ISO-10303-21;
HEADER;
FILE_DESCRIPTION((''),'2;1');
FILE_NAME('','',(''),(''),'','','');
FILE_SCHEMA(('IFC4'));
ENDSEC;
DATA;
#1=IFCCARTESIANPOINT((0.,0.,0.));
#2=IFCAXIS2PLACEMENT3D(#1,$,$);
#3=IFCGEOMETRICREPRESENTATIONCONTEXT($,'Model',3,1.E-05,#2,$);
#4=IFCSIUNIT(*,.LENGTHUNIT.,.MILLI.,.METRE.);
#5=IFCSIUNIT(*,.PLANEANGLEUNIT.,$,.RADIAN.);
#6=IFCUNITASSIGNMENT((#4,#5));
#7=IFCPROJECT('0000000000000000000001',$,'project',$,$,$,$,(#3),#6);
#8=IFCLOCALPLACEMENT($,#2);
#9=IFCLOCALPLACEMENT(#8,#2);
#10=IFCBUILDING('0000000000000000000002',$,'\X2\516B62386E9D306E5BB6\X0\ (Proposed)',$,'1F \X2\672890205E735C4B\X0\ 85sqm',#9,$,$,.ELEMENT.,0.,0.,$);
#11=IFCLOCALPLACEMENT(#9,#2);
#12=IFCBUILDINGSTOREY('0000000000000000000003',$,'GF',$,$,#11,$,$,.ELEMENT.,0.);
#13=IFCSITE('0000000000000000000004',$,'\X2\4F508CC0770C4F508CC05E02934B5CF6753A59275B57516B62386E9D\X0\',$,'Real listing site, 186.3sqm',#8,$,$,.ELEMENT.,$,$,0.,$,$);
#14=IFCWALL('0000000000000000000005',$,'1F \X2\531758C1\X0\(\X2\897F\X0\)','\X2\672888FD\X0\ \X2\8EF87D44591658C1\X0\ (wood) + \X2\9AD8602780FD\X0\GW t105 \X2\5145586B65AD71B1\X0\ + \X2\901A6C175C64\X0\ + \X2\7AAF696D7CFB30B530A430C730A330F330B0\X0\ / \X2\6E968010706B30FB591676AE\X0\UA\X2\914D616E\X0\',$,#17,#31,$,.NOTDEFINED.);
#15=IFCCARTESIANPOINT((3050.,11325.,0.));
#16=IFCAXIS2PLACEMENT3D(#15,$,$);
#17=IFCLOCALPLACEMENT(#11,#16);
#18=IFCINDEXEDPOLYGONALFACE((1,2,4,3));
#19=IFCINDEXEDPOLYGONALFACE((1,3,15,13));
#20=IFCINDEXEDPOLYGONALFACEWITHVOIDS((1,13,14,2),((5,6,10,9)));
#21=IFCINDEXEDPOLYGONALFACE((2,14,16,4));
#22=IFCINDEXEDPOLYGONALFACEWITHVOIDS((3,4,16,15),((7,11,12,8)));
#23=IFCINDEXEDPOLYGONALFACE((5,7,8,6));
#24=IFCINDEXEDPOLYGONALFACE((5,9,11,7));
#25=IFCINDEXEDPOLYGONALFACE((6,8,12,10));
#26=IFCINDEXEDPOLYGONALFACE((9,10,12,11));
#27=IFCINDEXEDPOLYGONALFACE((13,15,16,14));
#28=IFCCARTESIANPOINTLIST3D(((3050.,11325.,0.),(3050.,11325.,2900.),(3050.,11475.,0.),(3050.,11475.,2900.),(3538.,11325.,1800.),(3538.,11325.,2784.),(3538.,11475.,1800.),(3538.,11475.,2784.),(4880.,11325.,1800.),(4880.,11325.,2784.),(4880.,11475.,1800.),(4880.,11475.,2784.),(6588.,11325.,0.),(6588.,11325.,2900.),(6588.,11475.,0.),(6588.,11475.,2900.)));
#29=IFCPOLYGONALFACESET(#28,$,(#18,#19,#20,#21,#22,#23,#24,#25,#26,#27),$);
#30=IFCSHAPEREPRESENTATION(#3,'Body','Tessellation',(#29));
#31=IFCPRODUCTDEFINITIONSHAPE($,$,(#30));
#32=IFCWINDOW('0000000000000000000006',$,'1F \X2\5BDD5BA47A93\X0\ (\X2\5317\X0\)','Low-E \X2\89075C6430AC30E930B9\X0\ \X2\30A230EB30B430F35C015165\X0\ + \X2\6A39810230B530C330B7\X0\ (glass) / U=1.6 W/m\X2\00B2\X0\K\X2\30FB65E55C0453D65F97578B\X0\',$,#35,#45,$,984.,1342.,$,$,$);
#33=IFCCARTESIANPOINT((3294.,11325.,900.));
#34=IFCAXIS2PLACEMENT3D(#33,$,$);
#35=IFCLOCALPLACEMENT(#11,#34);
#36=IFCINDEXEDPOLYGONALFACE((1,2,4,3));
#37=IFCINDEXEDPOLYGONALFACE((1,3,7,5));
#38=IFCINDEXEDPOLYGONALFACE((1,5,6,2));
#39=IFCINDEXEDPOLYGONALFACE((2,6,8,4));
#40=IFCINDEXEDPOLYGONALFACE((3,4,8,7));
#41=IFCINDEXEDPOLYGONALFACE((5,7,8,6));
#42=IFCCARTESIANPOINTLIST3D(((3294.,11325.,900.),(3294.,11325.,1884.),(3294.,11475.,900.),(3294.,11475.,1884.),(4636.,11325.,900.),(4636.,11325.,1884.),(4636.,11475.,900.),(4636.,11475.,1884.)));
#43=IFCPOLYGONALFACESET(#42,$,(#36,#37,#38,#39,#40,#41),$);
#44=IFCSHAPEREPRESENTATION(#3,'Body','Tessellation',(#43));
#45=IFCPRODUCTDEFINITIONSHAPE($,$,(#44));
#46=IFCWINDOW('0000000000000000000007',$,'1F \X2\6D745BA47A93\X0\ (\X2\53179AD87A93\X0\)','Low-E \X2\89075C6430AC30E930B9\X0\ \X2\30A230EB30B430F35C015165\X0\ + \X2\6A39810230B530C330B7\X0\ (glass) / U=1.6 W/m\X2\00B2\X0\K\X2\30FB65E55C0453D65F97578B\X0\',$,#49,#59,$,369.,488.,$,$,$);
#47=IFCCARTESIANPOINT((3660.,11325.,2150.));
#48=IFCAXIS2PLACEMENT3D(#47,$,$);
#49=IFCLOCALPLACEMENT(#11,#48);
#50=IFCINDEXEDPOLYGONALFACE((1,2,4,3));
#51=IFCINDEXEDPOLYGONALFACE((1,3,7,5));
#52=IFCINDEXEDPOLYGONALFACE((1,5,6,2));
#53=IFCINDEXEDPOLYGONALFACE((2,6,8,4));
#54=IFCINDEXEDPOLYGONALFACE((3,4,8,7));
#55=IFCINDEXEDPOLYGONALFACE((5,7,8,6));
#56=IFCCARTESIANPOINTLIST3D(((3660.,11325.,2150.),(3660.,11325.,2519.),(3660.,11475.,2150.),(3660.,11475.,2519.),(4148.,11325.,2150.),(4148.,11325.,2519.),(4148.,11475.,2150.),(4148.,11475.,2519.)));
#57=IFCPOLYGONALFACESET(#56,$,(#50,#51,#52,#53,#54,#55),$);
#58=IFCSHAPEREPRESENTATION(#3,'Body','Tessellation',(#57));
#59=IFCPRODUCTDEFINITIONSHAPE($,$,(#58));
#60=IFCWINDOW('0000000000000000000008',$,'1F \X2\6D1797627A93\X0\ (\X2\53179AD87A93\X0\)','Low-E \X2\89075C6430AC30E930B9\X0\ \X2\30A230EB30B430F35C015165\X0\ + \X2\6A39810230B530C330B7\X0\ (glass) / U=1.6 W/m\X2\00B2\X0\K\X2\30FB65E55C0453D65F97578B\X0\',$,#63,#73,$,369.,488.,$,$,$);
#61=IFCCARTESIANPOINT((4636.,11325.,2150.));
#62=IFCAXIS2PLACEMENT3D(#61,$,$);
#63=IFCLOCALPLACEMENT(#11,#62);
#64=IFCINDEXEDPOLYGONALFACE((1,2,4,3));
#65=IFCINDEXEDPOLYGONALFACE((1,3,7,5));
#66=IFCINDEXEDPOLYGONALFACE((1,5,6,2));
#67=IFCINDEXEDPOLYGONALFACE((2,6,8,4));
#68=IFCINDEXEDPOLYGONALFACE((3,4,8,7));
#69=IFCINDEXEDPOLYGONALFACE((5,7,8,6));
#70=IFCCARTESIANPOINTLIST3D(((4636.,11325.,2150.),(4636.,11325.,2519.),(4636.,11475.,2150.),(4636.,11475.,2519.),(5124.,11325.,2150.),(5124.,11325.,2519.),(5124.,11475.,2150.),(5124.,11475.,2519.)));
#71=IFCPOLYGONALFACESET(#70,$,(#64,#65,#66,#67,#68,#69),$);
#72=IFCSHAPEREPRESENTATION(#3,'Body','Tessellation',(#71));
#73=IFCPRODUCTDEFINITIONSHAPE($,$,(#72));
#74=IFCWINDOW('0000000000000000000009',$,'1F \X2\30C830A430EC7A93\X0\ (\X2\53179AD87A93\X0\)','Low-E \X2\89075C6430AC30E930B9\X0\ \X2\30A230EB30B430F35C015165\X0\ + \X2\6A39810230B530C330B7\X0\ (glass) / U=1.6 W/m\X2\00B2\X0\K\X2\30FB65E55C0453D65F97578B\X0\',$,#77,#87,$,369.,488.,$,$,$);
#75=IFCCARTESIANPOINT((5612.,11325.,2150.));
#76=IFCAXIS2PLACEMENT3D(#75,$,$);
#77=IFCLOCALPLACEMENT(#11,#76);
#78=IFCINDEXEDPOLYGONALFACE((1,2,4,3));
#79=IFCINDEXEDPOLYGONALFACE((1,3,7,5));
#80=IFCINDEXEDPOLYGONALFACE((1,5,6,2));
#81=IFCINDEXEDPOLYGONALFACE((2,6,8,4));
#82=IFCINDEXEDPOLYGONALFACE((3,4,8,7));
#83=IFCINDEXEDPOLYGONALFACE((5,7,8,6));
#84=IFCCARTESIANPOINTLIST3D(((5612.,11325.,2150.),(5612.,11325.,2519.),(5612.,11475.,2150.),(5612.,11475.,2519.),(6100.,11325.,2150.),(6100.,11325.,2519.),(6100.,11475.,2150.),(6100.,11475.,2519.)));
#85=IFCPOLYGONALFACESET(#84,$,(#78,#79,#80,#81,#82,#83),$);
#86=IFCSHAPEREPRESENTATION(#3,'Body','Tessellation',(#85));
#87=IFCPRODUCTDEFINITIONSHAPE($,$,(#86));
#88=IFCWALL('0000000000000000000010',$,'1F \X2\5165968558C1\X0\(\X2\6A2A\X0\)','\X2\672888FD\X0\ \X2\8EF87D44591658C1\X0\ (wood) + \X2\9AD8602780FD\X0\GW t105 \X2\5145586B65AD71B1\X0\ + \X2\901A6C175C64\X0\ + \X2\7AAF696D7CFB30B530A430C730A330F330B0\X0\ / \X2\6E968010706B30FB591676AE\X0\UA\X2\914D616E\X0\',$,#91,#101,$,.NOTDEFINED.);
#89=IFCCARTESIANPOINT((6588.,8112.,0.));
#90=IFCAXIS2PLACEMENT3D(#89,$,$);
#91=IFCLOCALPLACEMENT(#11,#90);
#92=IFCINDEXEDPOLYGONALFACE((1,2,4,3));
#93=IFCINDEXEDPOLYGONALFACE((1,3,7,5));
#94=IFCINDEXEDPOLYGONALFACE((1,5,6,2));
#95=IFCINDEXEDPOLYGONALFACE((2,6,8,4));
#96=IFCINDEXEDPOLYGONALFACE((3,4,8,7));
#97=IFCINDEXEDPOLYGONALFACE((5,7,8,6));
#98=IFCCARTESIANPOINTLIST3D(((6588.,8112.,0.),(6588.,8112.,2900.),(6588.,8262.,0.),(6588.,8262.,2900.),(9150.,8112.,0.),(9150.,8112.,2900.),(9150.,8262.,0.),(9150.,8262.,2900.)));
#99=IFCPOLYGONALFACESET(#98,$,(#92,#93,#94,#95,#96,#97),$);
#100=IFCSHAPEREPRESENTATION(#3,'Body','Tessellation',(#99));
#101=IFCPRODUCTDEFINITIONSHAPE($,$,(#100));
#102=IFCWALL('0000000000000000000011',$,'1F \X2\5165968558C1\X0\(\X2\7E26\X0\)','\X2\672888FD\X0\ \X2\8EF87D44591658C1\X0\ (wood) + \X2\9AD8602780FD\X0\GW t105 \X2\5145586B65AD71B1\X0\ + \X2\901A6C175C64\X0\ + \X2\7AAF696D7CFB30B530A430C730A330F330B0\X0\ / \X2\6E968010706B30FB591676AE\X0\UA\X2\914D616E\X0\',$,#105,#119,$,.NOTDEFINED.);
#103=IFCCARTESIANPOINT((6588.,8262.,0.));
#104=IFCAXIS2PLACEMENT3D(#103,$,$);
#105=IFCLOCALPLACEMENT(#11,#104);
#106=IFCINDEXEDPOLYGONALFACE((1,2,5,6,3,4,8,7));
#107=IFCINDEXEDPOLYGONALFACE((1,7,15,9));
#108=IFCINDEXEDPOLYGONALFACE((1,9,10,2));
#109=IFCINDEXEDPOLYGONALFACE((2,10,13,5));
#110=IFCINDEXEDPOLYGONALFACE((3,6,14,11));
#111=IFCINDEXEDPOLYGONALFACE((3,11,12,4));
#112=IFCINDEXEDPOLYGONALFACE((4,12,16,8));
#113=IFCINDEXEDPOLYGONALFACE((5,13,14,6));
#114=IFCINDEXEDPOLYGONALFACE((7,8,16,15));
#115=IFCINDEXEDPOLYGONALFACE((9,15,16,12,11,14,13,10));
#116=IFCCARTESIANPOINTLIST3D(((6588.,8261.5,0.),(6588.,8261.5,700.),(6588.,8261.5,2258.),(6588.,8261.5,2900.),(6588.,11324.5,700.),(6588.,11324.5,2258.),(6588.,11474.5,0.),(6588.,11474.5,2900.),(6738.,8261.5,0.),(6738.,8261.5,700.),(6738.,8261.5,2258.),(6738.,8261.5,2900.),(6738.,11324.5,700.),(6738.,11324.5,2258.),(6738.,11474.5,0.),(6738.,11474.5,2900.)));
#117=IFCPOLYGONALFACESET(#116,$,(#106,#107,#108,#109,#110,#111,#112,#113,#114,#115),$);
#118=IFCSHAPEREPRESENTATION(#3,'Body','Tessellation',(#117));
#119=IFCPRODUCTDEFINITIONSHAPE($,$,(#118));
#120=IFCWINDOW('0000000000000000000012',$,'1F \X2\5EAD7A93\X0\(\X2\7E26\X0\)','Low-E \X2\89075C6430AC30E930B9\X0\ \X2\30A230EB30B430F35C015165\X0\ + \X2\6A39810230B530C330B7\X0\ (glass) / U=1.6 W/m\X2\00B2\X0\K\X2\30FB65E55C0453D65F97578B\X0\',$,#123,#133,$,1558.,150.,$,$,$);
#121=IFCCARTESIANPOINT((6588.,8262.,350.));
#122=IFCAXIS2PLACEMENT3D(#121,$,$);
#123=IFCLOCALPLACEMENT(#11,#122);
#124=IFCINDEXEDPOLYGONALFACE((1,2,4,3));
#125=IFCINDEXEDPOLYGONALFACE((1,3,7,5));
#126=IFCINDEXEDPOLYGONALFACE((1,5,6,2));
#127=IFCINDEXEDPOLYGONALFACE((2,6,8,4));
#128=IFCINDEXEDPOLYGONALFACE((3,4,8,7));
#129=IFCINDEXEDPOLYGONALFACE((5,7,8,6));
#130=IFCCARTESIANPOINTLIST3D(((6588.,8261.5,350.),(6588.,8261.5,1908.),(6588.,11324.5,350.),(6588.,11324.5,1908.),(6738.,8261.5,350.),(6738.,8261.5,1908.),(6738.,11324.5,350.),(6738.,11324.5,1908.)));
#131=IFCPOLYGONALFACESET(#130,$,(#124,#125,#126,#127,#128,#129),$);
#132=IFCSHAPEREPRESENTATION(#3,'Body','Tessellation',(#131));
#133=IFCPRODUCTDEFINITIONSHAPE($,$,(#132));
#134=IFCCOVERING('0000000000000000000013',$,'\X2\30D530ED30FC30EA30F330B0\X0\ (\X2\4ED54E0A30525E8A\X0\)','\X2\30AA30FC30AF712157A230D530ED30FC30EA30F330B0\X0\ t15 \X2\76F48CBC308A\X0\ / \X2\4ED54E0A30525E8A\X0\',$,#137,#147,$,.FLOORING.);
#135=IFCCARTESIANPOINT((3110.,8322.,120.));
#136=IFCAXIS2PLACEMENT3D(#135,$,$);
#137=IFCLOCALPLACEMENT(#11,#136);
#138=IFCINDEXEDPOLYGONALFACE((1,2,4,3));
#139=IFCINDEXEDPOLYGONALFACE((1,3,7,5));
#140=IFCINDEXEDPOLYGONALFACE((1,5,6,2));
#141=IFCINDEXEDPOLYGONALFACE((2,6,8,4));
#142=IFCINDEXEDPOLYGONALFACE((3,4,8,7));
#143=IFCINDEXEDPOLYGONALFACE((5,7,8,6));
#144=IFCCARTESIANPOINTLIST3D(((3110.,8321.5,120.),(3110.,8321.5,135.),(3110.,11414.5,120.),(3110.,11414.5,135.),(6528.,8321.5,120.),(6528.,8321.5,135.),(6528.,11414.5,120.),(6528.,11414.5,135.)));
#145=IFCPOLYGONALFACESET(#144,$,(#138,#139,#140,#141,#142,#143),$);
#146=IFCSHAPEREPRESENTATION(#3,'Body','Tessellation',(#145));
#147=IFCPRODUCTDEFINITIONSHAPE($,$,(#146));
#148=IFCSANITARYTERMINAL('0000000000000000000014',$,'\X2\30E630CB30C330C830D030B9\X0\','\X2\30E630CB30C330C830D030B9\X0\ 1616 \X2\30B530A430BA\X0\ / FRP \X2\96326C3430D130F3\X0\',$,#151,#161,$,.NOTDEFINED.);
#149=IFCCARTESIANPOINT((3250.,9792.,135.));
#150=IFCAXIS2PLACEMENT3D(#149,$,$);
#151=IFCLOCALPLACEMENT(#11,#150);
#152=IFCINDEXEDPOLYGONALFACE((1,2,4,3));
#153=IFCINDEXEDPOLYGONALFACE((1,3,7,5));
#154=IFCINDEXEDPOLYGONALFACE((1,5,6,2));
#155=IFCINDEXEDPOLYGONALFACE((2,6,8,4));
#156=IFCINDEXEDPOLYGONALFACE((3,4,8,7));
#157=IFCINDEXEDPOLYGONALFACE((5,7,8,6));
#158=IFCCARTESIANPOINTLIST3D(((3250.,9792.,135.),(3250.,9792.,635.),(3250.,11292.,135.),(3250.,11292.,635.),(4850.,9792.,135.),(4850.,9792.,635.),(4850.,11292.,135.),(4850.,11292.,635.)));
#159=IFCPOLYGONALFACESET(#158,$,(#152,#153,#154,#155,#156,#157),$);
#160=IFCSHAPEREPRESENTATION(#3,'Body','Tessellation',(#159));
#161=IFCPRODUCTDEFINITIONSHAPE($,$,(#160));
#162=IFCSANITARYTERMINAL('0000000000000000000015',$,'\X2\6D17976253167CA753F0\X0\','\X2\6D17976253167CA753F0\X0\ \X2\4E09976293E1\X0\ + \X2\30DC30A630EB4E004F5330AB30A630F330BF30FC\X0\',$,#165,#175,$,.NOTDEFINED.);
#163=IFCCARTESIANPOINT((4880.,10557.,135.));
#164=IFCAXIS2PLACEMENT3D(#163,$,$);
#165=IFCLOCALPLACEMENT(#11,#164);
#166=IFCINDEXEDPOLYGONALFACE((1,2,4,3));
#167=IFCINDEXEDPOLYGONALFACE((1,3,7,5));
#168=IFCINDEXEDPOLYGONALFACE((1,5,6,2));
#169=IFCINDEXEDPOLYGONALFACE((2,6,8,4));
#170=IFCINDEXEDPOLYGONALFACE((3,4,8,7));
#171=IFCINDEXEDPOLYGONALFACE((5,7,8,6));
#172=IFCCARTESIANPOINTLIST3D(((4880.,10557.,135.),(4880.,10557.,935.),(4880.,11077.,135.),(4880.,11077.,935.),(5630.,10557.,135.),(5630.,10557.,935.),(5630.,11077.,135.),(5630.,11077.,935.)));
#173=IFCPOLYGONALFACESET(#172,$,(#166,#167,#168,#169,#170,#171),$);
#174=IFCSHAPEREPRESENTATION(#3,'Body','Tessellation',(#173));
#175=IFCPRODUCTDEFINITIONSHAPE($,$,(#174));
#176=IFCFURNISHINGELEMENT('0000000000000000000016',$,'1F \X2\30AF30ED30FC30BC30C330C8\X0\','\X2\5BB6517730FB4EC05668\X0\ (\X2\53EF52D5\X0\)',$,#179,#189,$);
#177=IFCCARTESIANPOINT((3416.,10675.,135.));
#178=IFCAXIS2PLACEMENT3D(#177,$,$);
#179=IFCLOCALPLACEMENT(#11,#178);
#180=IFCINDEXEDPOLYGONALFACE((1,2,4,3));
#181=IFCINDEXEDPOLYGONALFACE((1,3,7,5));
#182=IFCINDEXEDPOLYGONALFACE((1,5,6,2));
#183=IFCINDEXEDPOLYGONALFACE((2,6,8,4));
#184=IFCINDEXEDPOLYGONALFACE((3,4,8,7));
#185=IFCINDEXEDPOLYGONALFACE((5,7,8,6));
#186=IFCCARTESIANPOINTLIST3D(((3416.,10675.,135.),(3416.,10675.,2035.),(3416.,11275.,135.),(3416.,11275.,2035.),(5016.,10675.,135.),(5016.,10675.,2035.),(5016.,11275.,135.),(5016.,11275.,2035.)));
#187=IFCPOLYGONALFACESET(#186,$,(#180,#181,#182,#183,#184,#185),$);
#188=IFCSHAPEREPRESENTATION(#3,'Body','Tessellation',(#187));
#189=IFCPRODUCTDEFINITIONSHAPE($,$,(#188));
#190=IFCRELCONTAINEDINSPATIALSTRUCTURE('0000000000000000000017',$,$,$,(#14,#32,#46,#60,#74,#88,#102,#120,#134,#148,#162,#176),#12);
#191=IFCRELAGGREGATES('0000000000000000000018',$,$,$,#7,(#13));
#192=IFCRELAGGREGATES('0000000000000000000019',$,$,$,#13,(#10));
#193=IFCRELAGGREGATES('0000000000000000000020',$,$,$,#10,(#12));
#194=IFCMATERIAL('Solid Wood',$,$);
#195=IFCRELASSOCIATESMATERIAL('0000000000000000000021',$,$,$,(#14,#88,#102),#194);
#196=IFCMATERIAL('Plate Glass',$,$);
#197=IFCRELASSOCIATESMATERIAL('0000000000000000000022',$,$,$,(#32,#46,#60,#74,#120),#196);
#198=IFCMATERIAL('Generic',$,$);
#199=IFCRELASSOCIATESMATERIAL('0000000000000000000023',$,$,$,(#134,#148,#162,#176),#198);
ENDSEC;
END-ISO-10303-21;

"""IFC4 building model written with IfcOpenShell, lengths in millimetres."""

from ifc_helpers import new_model, si_unit, frame, frame_2d, origin, place, context, project, spatial, rectangle, extrude, material, element, fill, save


model = new_model("IFC4")

# Units and contexts
model_context = context("Model", 3, precision=1e-05, world=origin())
ifc_project = project(units=[si_unit("LENGTHUNIT", "METRE", prefix="MILLI"), si_unit("PLANEANGLEUNIT", "RADIAN")], contexts=[model_context])

# Site, building, storey
site_placement = place(None, origin())
site = spatial("IfcSite", under=ifc_project, at=site_placement, Name="佐賀県佐賀市鍋島町大字八戸溝", ObjectType="Real listing site, 186.3sqm", CompositionType="ELEMENT", RefElevation=0.0)
building_placement = place(site_placement, origin())
building = spatial("IfcBuilding", under=site, at=building_placement, Name="八戸溝の家 (Proposed)", ObjectType="1F 木造平屋 85sqm", CompositionType="ELEMENT", ElevationOfRefHeight=0.0, ElevationOfTerrain=0.0)
storey_placement = place(building_placement, origin())
storey = spatial("IfcBuildingStorey", under=building, at=storey_placement, Name="GF", CompositionType="ELEMENT", Elevation=0.0)

# Shared definitions
ifc_material_1 = material(Name="Solid Wood")

# Wall, openings, windows
wall_1_placement = place(storey_placement, frame((3050.0, 11325.0, 0.0)))
wall_1 = element("IfcWall", 1, at=wall_1_placement, inside=storey, material=ifc_material_1, Name="1F 北壁(西)", Description="木製 軸組外壁 (wood) + 高性能GW t105 充填断熱 + 通気層 + 窯業系サイディング / 準耐火・外皮UA配慮", PredefinedType="NOTDEFINED", context=model_context, shape_type="SweptSolid", body=[
    extrude(rectangle(XDim=3538.0, YDim=150.0, at=frame_2d((1769.0, 75.0))), frame((3050.0, 11325.0, 0.0)), (0.0, 0.0, 1.0), 2900.0),
])
opening_1_placement = place(storey_placement, frame((3294.0, 11325.0, 900.0)))
opening_1 = element("IfcOpeningElement", 2, at=opening_1_placement, cuts=wall_1, PredefinedType="NOTDEFINED", context=model_context, shape_type="SweptSolid", body=[
    extrude(rectangle(XDim=1342.0, YDim=150.0, at=frame_2d((671.0, 75.0))), frame((3294.0, 11325.0, 900.0)), (0.0, 0.0, 1.0), 984.0),
])
opening_2_placement = place(storey_placement, frame((3660.0, 11325.0, 2150.0)))
opening_2 = element("IfcOpeningElement", 3, at=opening_2_placement, cuts=wall_1, PredefinedType="NOTDEFINED", context=model_context, shape_type="SweptSolid", body=[
    extrude(rectangle(XDim=488.0, YDim=150.0, at=frame_2d((244.0, 75.0))), frame((3660.0, 11325.0, 2150.0)), (0.0, 0.0, 1.0), 369.0),
])
opening_3_placement = place(storey_placement, frame((4636.0, 11325.0, 2150.0)))
opening_3 = element("IfcOpeningElement", 4, at=opening_3_placement, cuts=wall_1, PredefinedType="NOTDEFINED", context=model_context, shape_type="SweptSolid", body=[
    extrude(rectangle(XDim=488.0, YDim=150.0, at=frame_2d((244.0, 75.0))), frame((4636.0, 11325.0, 2150.0)), (0.0, 0.0, 1.0), 369.0),
])
opening_4_placement = place(storey_placement, frame((5612.0, 11325.0, 2150.0)))
opening_4 = element("IfcOpeningElement", 5, at=opening_4_placement, cuts=wall_1, PredefinedType="NOTDEFINED", context=model_context, shape_type="SweptSolid", body=[
    extrude(rectangle(XDim=488.0, YDim=150.0, at=frame_2d((244.0, 75.0))), frame((5612.0, 11325.0, 2150.0)), (0.0, 0.0, 1.0), 369.0),
])
ifc_material_2 = material(Name="Plate Glass")
window_1_placement = place(storey_placement, frame((3294.0, 11325.0, 900.0)))
window_1 = element("IfcWindow", 6, at=window_1_placement, inside=storey, material=ifc_material_2, Name="1F 寝室窓 (北)", Description="Low-E 複層ガラス アルゴン封入 + 樹脂サッシ (glass) / U=1.6 W/m²K・日射取得型", OverallHeight=984.0, OverallWidth=1342.0, context=model_context, shape_type="SweptSolid", body=[
    extrude(rectangle(XDim=1342.0, YDim=150.0, at=frame_2d((671.0, 75.0))), frame((3294.0, 11325.0, 900.0)), (0.0, 0.0, 1.0), 984.0),
])
fill(opening_1, window_1)
window_2_placement = place(storey_placement, frame((3660.0, 11325.0, 2150.0)))
window_2 = element("IfcWindow", 7, at=window_2_placement, inside=storey, material=ifc_material_2, Name="1F 浴室窓 (北高窓)", Description="Low-E 複層ガラス アルゴン封入 + 樹脂サッシ (glass) / U=1.6 W/m²K・日射取得型", OverallHeight=369.0, OverallWidth=488.0, context=model_context, shape_type="SweptSolid", body=[
    extrude(rectangle(XDim=488.0, YDim=150.0, at=frame_2d((244.0, 75.0))), frame((3660.0, 11325.0, 2150.0)), (0.0, 0.0, 1.0), 369.0),
])
fill(opening_2, window_2)
window_3_placement = place(storey_placement, frame((4636.0, 11325.0, 2150.0)))
window_3 = element("IfcWindow", 8, at=window_3_placement, inside=storey, material=ifc_material_2, Name="1F 洗面窓 (北高窓)", Description="Low-E 複層ガラス アルゴン封入 + 樹脂サッシ (glass) / U=1.6 W/m²K・日射取得型", OverallHeight=369.0, OverallWidth=488.0, context=model_context, shape_type="SweptSolid", body=[
    extrude(rectangle(XDim=488.0, YDim=150.0, at=frame_2d((244.0, 75.0))), frame((4636.0, 11325.0, 2150.0)), (0.0, 0.0, 1.0), 369.0),
])
fill(opening_3, window_3)
window_4_placement = place(storey_placement, frame((5612.0, 11325.0, 2150.0)))
window_4 = element("IfcWindow", 9, at=window_4_placement, inside=storey, material=ifc_material_2, Name="1F トイレ窓 (北高窓)", Description="Low-E 複層ガラス アルゴン封入 + 樹脂サッシ (glass) / U=1.6 W/m²K・日射取得型", OverallHeight=369.0, OverallWidth=488.0, context=model_context, shape_type="SweptSolid", body=[
    extrude(rectangle(XDim=488.0, YDim=150.0, at=frame_2d((244.0, 75.0))), frame((5612.0, 11325.0, 2150.0)), (0.0, 0.0, 1.0), 369.0),
])
fill(opening_4, window_4)

# Wall
wall_2_placement = place(storey_placement, frame((6588.0, 8112.0, 0.0)))
element("IfcWall", 10, at=wall_2_placement, inside=storey, material=ifc_material_1, Name="1F 入隅壁(横)", Description="木製 軸組外壁 (wood) + 高性能GW t105 充填断熱 + 通気層 + 窯業系サイディング / 準耐火・外皮UA配慮", PredefinedType="NOTDEFINED", context=model_context, shape_type="SweptSolid", body=[
    extrude(rectangle(XDim=2562.0, YDim=150.0, at=frame_2d((1281.0, 75.0))), frame((6588.0, 8112.0, 0.0)), (0.0, 0.0, 1.0), 2900.0),
])

# Wall, opening, window
wall_3_placement = place(storey_placement, frame((6588.0, 8262.0, 0.0)))
wall_3 = element("IfcWall", 11, at=wall_3_placement, inside=storey, material=ifc_material_1, Name="1F 入隅壁(縦)", Description="木製 軸組外壁 (wood) + 高性能GW t105 充填断熱 + 通気層 + 窯業系サイディング / 準耐火・外皮UA配慮", PredefinedType="NOTDEFINED", context=model_context, shape_type="SweptSolid", body=[
    extrude(rectangle(XDim=150.0, YDim=3213.0, at=frame_2d((75.0, 1606.0))), frame((6588.0, 8262.0, 0.0)), (0.0, 0.0, 1.0), 2900.0),
])
opening_5_placement = place(storey_placement, frame((6588.0, 8262.0, 350.0)))
opening_5 = element("IfcOpeningElement", 12, at=opening_5_placement, cuts=wall_3, PredefinedType="NOTDEFINED", context=model_context, shape_type="SweptSolid", body=[
    extrude(rectangle(XDim=150.0, YDim=3063.0, at=frame_2d((75.0, 1531.0))), frame((6588.0, 8262.0, 350.0)), (0.0, 0.0, 1.0), 1558.0),
])
window_5_placement = place(storey_placement, frame((6588.0, 8262.0, 350.0)))
window_5 = element("IfcWindow", 13, at=window_5_placement, inside=storey, material=ifc_material_2, Name="1F 庭窓(縦)", Description="Low-E 複層ガラス アルゴン封入 + 樹脂サッシ (glass) / U=1.6 W/m²K・日射取得型", OverallHeight=1558.0, OverallWidth=150.0, context=model_context, shape_type="SweptSolid", body=[
    extrude(rectangle(XDim=150.0, YDim=3063.0, at=frame_2d((75.0, 1531.0))), frame((6588.0, 8262.0, 350.0)), (0.0, 0.0, 1.0), 1558.0),
])
fill(opening_5, window_5)

# Covering
ifc_material_3 = material(Name="Generic")
covering_placement = place(storey_placement, frame((3110.0, 8322.0, 120.0)))
element("IfcCovering", 14, at=covering_placement, inside=storey, material=ifc_material_3, Name="フローリング (仕上げ床)", Description="オーク無垢フローリング t15 直貼り / 仕上げ床", PredefinedType="FLOORING", context=model_context, shape_type="SweptSolid", body=[
    extrude(rectangle(XDim=3418.0, YDim=3093.0, at=frame_2d((1709.0, 1546.0))), frame((3110.0, 8322.0, 120.0)), (0.0, 0.0, 1.0), 15.0),
])

# Sanitary terminals
sanitary_terminal_1_placement = place(storey_placement, frame((3250.0, 9792.0, 135.0)))
element("IfcSanitaryTerminal", 15, at=sanitary_terminal_1_placement, inside=storey, material=ifc_material_3, Name="ユニットバス", Description="ユニットバス 1616 サイズ / FRP 防水パン", PredefinedType="NOTDEFINED", context=model_context, shape_type="SweptSolid", body=[
    extrude(rectangle(XDim=1600.0, YDim=1500.0, at=frame_2d((800.0, 750.0))), frame((3250.0, 9792.0, 135.0)), (0.0, 0.0, 1.0), 500.0),
])
sanitary_terminal_2_placement = place(storey_placement, frame((4880.0, 10557.0, 135.0)))
element("IfcSanitaryTerminal", 16, at=sanitary_terminal_2_placement, inside=storey, material=ifc_material_3, Name="洗面化粧台", Description="洗面化粧台 三面鏡 + ボウル一体カウンター", PredefinedType="NOTDEFINED", context=model_context, shape_type="SweptSolid", body=[
    extrude(rectangle(XDim=750.0, YDim=520.0, at=frame_2d((375.0, 260.0))), frame((4880.0, 10557.0, 135.0)), (0.0, 0.0, 1.0), 800.0),
])

# Furnishing element
furnishing_1_placement = place(storey_placement, frame((3416.0, 10675.0, 135.0)))
element("IfcFurnishingElement", 17, at=furnishing_1_placement, inside=storey, material=ifc_material_3, Name="1F クローゼット", Description="家具・什器 (可動)", context=model_context, shape_type="SweptSolid", body=[
    extrude(rectangle(XDim=1600.0, YDim=600.0, at=frame_2d((800.0, 300.0))), frame((3416.0, 10675.0, 135.0)), (0.0, 0.0, 1.0), 1900.0),
])

save(model, "model.ifc")
